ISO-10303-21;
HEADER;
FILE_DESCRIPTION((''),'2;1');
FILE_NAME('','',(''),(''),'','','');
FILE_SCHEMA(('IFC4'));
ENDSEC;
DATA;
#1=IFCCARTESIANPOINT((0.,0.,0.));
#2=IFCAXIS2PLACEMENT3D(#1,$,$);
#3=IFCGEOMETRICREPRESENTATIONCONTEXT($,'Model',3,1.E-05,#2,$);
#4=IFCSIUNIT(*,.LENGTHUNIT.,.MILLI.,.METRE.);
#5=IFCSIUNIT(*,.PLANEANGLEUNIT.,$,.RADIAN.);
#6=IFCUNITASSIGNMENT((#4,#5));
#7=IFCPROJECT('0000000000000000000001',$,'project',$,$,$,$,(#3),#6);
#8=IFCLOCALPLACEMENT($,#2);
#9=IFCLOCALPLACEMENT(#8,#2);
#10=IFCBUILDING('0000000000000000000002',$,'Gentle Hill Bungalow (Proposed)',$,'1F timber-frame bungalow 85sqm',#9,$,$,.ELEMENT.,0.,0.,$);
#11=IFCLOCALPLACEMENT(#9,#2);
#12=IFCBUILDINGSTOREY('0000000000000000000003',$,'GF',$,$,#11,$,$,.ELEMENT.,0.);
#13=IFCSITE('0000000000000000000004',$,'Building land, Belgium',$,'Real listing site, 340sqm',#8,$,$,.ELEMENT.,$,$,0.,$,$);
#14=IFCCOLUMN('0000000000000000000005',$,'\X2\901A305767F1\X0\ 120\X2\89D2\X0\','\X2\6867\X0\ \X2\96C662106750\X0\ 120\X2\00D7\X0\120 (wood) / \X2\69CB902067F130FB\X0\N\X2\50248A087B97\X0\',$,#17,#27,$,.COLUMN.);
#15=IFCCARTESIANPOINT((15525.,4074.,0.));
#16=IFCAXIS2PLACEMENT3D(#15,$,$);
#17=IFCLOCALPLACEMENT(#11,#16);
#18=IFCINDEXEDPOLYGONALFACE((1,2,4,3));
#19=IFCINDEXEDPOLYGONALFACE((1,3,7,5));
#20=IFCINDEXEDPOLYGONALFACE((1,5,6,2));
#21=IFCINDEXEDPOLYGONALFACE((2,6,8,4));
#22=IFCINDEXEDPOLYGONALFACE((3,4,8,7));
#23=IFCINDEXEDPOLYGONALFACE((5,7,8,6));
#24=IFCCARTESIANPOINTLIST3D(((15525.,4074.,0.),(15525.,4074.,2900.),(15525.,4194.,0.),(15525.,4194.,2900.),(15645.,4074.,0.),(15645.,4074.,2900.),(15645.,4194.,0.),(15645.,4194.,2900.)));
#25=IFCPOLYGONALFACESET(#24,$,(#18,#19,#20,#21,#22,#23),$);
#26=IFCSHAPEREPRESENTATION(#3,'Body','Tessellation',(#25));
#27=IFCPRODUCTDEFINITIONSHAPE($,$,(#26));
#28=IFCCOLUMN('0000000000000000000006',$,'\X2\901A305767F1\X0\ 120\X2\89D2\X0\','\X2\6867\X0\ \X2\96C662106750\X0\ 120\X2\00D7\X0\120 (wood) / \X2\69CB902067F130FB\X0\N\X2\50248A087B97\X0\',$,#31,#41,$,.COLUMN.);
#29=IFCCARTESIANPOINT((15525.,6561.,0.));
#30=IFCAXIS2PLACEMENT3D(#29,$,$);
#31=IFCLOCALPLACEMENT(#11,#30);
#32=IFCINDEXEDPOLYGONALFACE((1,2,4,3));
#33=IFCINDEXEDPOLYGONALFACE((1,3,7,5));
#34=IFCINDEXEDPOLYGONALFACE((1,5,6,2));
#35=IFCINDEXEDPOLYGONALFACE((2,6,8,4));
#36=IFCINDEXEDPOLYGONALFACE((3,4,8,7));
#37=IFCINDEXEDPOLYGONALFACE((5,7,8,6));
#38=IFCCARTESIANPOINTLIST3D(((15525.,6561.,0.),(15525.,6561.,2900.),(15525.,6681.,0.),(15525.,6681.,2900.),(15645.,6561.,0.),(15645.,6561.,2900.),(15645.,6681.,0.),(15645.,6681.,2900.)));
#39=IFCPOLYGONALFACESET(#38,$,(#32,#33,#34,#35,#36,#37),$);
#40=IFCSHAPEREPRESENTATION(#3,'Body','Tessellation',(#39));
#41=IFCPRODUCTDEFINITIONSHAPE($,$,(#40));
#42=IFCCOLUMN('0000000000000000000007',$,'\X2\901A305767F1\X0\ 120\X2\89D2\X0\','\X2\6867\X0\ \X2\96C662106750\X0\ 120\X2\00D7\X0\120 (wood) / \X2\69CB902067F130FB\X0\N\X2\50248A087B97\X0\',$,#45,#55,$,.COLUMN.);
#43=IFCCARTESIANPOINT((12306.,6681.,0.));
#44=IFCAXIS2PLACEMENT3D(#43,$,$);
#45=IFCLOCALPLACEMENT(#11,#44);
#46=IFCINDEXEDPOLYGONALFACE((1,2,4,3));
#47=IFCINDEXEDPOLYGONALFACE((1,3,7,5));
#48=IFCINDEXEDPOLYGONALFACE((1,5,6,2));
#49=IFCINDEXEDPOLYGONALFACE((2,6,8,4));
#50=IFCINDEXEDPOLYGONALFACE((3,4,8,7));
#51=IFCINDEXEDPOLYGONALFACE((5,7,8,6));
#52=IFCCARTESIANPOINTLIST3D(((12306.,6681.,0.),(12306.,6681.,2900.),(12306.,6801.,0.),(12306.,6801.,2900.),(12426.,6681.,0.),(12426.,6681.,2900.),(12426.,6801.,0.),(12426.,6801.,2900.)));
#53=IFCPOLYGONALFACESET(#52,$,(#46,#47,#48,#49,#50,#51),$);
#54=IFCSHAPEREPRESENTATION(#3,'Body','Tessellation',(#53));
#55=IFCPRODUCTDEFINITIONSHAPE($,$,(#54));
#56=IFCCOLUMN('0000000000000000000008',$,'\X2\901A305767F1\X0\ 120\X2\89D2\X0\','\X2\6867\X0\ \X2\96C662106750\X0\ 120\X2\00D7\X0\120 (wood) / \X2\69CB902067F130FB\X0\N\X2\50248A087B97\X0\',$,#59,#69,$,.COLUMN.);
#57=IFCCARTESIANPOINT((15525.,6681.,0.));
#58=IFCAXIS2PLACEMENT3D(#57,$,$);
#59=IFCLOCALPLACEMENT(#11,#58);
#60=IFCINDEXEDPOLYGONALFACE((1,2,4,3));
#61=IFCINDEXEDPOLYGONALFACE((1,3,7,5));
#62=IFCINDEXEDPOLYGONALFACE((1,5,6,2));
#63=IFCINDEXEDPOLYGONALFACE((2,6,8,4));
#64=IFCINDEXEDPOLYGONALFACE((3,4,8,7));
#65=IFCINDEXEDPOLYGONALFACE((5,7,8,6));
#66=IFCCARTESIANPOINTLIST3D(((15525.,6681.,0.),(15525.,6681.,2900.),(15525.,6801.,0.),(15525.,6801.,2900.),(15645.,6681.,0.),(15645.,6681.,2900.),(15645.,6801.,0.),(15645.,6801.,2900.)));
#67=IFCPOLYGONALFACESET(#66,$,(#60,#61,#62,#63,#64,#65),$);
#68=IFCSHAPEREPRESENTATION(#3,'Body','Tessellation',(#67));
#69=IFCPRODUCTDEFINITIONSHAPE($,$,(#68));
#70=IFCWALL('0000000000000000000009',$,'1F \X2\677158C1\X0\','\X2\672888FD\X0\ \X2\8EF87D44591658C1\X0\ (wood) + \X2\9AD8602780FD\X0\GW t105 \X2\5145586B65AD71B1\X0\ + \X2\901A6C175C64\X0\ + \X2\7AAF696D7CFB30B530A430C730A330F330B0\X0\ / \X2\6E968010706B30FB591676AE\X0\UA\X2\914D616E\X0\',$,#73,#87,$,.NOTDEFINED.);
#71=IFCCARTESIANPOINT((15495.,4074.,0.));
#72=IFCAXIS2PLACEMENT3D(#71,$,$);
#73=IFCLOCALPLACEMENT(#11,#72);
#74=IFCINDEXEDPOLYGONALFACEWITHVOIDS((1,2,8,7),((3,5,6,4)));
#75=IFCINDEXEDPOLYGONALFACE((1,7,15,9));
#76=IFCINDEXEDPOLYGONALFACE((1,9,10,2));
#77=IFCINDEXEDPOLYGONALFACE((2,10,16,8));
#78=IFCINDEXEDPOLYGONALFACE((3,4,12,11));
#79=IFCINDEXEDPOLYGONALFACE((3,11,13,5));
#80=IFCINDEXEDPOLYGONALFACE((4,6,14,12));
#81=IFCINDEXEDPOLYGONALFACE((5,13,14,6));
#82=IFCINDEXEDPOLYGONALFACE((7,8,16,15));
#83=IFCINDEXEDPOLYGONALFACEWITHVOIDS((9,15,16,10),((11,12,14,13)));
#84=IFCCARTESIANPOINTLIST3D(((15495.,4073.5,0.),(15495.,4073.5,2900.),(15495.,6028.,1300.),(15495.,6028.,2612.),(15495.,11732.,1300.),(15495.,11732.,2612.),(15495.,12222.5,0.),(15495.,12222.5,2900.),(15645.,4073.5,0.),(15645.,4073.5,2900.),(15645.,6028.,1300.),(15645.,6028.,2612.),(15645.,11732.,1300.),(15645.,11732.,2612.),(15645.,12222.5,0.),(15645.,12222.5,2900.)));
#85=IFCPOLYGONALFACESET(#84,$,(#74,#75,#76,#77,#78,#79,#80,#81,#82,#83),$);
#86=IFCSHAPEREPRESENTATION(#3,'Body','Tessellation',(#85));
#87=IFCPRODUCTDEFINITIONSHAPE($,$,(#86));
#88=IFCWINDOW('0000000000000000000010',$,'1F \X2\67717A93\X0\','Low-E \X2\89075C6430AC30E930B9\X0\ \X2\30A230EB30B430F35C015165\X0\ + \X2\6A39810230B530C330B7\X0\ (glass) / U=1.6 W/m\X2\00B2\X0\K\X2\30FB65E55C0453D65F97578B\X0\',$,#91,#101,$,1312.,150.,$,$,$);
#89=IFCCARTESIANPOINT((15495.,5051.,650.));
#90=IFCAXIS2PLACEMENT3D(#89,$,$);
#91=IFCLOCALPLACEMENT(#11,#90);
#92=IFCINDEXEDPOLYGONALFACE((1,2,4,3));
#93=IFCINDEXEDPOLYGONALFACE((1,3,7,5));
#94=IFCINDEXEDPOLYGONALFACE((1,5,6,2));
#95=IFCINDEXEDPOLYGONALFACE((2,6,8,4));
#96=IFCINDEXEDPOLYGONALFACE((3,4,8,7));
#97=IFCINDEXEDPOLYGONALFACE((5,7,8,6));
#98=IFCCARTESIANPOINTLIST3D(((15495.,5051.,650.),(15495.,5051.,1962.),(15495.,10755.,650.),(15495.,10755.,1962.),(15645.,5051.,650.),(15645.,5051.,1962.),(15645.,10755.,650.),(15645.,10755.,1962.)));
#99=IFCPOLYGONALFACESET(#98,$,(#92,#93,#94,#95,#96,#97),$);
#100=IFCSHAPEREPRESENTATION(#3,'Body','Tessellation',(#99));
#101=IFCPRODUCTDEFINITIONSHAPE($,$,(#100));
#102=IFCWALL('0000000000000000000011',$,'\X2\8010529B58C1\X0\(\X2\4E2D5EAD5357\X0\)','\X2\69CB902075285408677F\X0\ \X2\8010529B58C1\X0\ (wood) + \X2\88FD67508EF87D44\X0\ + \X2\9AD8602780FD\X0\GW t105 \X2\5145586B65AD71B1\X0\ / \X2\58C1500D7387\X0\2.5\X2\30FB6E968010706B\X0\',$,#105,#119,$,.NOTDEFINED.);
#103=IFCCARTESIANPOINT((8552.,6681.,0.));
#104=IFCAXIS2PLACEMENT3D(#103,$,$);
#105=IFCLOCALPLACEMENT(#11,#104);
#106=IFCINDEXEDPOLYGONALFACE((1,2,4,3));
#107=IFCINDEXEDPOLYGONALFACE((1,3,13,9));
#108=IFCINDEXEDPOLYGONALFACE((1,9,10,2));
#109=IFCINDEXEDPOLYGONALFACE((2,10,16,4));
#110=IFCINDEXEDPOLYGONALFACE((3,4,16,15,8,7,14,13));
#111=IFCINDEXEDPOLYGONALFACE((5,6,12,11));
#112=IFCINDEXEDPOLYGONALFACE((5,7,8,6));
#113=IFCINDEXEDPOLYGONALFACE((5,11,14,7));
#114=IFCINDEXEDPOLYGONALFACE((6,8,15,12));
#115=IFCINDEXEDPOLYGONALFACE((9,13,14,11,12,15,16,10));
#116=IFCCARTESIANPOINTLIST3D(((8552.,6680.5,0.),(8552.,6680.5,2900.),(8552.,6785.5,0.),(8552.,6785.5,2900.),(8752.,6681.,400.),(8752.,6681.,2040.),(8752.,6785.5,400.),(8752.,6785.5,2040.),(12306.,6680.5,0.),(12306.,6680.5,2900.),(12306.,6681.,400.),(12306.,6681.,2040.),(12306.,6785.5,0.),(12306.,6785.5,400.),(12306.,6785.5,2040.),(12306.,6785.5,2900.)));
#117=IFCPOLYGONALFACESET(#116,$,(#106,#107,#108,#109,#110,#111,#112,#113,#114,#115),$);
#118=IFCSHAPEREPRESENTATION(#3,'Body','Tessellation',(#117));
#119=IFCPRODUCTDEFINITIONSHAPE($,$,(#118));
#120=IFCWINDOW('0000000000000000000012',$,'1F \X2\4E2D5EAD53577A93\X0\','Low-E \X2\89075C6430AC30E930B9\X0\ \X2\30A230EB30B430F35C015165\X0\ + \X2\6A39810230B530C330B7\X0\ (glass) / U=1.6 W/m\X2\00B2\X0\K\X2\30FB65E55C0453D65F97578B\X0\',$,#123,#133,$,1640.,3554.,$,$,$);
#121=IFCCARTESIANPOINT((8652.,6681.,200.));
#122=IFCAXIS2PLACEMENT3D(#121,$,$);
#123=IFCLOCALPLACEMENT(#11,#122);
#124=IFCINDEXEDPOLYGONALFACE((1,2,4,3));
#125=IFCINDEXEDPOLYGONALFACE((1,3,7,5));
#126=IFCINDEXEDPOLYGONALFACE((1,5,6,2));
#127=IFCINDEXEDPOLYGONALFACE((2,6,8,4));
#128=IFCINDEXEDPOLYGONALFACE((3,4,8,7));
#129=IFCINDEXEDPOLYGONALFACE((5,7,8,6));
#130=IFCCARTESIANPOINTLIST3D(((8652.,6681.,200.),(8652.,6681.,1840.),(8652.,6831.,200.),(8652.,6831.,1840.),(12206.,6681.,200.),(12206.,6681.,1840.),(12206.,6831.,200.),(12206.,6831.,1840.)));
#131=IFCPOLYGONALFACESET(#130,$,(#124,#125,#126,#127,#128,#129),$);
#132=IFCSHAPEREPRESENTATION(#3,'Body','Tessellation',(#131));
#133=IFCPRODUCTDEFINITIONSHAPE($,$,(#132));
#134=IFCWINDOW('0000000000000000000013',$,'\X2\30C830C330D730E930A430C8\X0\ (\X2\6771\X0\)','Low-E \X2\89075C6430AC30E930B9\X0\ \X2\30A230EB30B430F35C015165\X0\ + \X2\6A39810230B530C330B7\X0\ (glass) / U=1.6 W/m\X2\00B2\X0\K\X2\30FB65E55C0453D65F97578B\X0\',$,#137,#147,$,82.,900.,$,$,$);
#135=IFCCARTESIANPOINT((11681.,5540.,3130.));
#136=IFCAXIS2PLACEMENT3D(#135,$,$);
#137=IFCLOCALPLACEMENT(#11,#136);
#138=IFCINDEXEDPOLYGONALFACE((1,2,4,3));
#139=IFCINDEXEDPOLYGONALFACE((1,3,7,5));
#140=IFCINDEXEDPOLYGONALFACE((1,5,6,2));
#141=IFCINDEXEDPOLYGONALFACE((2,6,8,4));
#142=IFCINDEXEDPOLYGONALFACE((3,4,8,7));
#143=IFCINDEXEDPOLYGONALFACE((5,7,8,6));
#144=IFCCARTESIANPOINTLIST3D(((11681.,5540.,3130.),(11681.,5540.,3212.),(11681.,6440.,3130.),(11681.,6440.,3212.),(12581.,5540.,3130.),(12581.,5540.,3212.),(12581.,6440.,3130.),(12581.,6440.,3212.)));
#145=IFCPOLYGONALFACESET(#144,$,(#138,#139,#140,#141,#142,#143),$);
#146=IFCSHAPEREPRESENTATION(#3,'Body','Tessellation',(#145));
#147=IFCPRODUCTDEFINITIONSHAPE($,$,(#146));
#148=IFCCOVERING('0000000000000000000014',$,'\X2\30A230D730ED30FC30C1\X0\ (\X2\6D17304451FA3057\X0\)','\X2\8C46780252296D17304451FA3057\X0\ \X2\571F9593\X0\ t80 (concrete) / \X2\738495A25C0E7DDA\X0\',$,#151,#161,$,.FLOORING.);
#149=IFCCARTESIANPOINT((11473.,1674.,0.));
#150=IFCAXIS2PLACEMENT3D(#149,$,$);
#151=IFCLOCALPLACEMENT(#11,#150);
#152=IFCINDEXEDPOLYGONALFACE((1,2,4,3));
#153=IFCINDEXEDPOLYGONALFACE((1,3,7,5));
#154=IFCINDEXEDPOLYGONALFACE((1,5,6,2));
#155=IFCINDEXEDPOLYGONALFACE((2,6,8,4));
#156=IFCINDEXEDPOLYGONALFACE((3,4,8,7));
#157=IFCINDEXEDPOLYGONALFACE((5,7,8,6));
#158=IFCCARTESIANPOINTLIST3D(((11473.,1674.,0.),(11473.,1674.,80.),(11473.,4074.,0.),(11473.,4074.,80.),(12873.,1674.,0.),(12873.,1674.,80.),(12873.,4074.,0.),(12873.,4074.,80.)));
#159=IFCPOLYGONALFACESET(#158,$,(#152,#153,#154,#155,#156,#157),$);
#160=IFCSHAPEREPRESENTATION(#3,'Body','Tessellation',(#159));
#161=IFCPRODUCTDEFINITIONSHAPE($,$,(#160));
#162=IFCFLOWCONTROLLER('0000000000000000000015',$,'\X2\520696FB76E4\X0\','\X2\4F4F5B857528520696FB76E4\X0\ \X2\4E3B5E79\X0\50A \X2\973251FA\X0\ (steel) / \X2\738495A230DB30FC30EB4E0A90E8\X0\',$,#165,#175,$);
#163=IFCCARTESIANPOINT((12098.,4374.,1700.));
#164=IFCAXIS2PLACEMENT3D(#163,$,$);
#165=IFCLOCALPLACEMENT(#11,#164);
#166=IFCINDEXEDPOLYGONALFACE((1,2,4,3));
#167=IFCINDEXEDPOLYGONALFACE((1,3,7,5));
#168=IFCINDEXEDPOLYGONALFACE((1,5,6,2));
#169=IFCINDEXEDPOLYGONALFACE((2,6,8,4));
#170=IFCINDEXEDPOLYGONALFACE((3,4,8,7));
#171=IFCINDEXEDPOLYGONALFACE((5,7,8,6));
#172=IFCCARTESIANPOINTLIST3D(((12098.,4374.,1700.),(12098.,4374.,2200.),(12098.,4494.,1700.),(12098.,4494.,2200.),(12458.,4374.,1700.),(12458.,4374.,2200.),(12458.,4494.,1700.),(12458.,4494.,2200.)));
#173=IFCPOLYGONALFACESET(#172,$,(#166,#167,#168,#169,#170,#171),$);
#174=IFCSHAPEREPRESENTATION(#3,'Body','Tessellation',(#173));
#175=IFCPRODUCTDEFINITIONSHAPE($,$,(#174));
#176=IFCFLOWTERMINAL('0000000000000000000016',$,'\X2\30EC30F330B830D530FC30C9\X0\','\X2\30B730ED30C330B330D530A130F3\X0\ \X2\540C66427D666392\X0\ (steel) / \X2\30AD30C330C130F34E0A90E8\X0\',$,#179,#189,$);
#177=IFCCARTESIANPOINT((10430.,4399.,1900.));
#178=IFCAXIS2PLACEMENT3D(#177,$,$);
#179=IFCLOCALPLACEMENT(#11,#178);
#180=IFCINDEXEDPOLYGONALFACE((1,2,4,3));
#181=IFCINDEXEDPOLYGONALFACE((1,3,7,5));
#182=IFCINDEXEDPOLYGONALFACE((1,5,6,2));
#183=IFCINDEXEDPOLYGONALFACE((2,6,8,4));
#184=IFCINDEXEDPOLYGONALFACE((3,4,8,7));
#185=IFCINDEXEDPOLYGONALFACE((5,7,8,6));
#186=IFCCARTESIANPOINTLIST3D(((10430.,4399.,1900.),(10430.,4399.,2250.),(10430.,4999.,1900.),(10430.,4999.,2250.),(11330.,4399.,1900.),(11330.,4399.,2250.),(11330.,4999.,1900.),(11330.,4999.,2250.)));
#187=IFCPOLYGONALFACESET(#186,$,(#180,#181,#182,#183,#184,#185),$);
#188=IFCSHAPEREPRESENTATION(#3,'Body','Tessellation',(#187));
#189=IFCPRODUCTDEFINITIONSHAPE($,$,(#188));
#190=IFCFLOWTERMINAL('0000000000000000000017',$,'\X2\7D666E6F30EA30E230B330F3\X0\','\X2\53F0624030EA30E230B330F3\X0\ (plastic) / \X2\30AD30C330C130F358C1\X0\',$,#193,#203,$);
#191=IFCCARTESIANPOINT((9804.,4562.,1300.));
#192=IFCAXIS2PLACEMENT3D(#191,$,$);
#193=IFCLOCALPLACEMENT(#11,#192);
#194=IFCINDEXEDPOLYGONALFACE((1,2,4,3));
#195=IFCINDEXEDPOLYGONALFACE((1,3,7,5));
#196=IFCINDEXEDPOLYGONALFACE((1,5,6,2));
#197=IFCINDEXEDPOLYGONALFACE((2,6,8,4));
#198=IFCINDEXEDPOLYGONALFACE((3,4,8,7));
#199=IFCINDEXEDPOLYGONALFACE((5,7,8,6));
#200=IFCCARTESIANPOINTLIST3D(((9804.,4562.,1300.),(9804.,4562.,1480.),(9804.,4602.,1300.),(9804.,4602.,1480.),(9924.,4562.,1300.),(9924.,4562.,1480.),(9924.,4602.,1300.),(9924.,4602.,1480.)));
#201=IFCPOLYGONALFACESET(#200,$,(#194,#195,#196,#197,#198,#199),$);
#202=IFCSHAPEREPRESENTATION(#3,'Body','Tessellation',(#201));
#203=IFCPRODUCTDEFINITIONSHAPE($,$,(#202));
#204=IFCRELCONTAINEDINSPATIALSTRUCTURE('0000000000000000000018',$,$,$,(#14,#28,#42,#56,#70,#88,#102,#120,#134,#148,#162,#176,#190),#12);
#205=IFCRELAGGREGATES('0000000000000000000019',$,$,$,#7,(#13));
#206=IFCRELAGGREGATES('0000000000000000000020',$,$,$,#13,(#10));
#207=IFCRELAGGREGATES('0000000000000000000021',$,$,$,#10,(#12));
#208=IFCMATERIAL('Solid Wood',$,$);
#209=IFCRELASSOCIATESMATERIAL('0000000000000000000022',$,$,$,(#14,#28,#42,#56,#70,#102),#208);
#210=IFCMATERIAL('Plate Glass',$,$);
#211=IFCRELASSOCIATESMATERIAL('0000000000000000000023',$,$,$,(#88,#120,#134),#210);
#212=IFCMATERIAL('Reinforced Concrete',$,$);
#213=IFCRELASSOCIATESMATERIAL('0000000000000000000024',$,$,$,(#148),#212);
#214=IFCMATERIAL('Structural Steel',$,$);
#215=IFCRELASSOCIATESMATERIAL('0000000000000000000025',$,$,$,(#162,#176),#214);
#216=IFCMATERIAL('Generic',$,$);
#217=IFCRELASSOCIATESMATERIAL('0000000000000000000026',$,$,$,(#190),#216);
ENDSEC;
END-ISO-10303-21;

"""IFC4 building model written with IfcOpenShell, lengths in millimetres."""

from ifc_helpers import new_model, si_unit, frame, frame_2d, origin, place, context, project, spatial, rectangle, extrude, material, element, fill, save


model = new_model("IFC4")

# Units and contexts
model_context = context("Model", 3, precision=1e-05, world=origin())
ifc_project = project(units=[si_unit("LENGTHUNIT", "METRE", prefix="MILLI"), si_unit("PLANEANGLEUNIT", "RADIAN")], contexts=[model_context])

# Site, building, storey
site_placement = place(None, origin())
site = spatial("IfcSite", under=ifc_project, at=site_placement, Name="Building land, Belgium", ObjectType="Real listing site, 340sqm", CompositionType="ELEMENT", RefElevation=0.0)
building_placement = place(site_placement, origin())
building = spatial("IfcBuilding", under=site, at=building_placement, Name="Gentle Hill Bungalow (Proposed)", ObjectType="1F timber-frame bungalow 85sqm", CompositionType="ELEMENT", ElevationOfRefHeight=0.0, ElevationOfTerrain=0.0)
storey_placement = place(building_placement, origin())
storey = spatial("IfcBuildingStorey", under=building, at=storey_placement, Name="GF", CompositionType="ELEMENT", Elevation=0.0)

# Columns
ifc_material_1 = material(Name="Solid Wood")
column_1_placement = place(storey_placement, frame((15525.0, 4074.0, 0.0)))
element("IfcColumn", 1, at=column_1_placement, inside=storey, material=ifc_material_1, Name="通し柱 120角", Description="桧 集成材 120×120 (wood) / 構造柱・N値計算", PredefinedType="COLUMN", context=model_context, shape_type="SweptSolid", body=[
    extrude(rectangle(XDim=120.0, YDim=120.0, at=frame_2d((60.0, 60.0))), frame((15525.0, 4074.0, 0.0)), (0.0, 0.0, 1.0), 2900.0),
])
column_2_placement = place(storey_placement, frame((15525.0, 6561.0, 0.0)))
element("IfcColumn", 2, at=column_2_placement, inside=storey, material=ifc_material_1, Name="通し柱 120角", Description="桧 集成材 120×120 (wood) / 構造柱・N値計算", PredefinedType="COLUMN", context=model_context, shape_type="SweptSolid", body=[
    extrude(rectangle(XDim=120.0, YDim=120.0, at=frame_2d((60.0, 60.0))), frame((15525.0, 6561.0, 0.0)), (0.0, 0.0, 1.0), 2900.0),
])
column_3_placement = place(storey_placement, frame((12306.0, 6681.0, 0.0)))
element("IfcColumn", 3, at=column_3_placement, inside=storey, material=ifc_material_1, Name="通し柱 120角", Description="桧 集成材 120×120 (wood) / 構造柱・N値計算", PredefinedType="COLUMN", context=model_context, shape_type="SweptSolid", body=[
    extrude(rectangle(XDim=120.0, YDim=120.0, at=frame_2d((60.0, 60.0))), frame((12306.0, 6681.0, 0.0)), (0.0, 0.0, 1.0), 2900.0),
])
column_4_placement = place(storey_placement, frame((15525.0, 6681.0, 0.0)))
element("IfcColumn", 4, at=column_4_placement, inside=storey, material=ifc_material_1, Name="通し柱 120角", Description="桧 集成材 120×120 (wood) / 構造柱・N値計算", PredefinedType="COLUMN", context=model_context, shape_type="SweptSolid", body=[
    extrude(rectangle(XDim=120.0, YDim=120.0, at=frame_2d((60.0, 60.0))), frame((15525.0, 6681.0, 0.0)), (0.0, 0.0, 1.0), 2900.0),
])

# Walls, openings, windows
wall_1_placement = place(storey_placement, frame((15495.0, 4074.0, 0.0)))
wall_1 = element("IfcWall", 5, at=wall_1_placement, inside=storey, material=ifc_material_1, Name="1F 東壁", Description="木製 軸組外壁 (wood) + 高性能GW t105 充填断熱 + 通気層 + 窯業系サイディング / 準耐火・外皮UA配慮", PredefinedType="NOTDEFINED", context=model_context, shape_type="SweptSolid", body=[
    extrude(rectangle(XDim=150.0, YDim=8149.0, at=frame_2d((75.0, 4074.0))), frame((15495.0, 4074.0, 0.0)), (0.0, 0.0, 1.0), 2900.0),
])
opening_1_placement = place(storey_placement, frame((15495.0, 5051.0, 650.0)))
opening_1 = element("IfcOpeningElement", 6, at=opening_1_placement, cuts=wall_1, PredefinedType="NOTDEFINED", context=model_context, shape_type="SweptSolid", body=[
    extrude(rectangle(XDim=150.0, YDim=5704.0, at=frame_2d((75.0, 2852.0))), frame((15495.0, 5051.0, 650.0)), (0.0, 0.0, 1.0), 1312.0),
])
ifc_material_2 = material(Name="Plate Glass")
window_1_placement = place(storey_placement, frame((15495.0, 5051.0, 650.0)))
window_1 = element("IfcWindow", 7, at=window_1_placement, inside=storey, material=ifc_material_2, Name="1F 東窓", Description="Low-E 複層ガラス アルゴン封入 + 樹脂サッシ (glass) / U=1.6 W/m²K・日射取得型", OverallHeight=1312.0, OverallWidth=150.0, context=model_context, shape_type="SweptSolid", body=[
    extrude(rectangle(XDim=150.0, YDim=5704.0, at=frame_2d((75.0, 2852.0))), frame((15495.0, 5051.0, 650.0)), (0.0, 0.0, 1.0), 1312.0),
])
fill(opening_1, window_1)
wall_2_placement = place(storey_placement, frame((8552.0, 6681.0, 0.0)))
wall_2 = element("IfcWall", 8, at=wall_2_placement, inside=storey, material=ifc_material_1, Name="耐力壁(中庭南)", Description="構造用合板 耐力壁 (wood) + 製材軸組 + 高性能GW t105 充填断熱 / 壁倍率2.5・準耐火", PredefinedType="NOTDEFINED", context=model_context, shape_type="SweptSolid", body=[
    extrude(rectangle(XDim=3754.0, YDim=105.0, at=frame_2d((1877.0, 52.0))), frame((8552.0, 6681.0, 0.0)), (0.0, 0.0, 1.0), 2900.0),
])
opening_2_placement = place(storey_placement, frame((8652.0, 6681.0, 200.0)))
opening_2 = element("IfcOpeningElement", 9, at=opening_2_placement, cuts=wall_2, PredefinedType="NOTDEFINED", context=model_context, shape_type="SweptSolid", body=[
    extrude(rectangle(XDim=3554.0, YDim=150.0, at=frame_2d((1777.0, 75.0))), frame((8652.0, 6681.0, 200.0)), (0.0, 0.0, 1.0), 1640.0),
])
window_2_placement = place(storey_placement, frame((8652.0, 6681.0, 200.0)))
window_2 = element("IfcWindow", 10, at=window_2_placement, inside=storey, material=ifc_material_2, Name="1F 中庭南窓", Description="Low-E 複層ガラス アルゴン封入 + 樹脂サッシ (glass) / U=1.6 W/m²K・日射取得型", OverallHeight=1640.0, OverallWidth=3554.0, context=model_context, shape_type="SweptSolid", body=[
    extrude(rectangle(XDim=3554.0, YDim=150.0, at=frame_2d((1777.0, 75.0))), frame((8652.0, 6681.0, 200.0)), (0.0, 0.0, 1.0), 1640.0),
])
fill(opening_2, window_2)

# Window
window_3_placement = place(storey_placement, frame((11681.0, 5540.0, 3130.0)))
element("IfcWindow", 11, at=window_3_placement, inside=storey, material=ifc_material_2, Name="トップライト (東)", Description="Low-E 複層ガラス アルゴン封入 + 樹脂サッシ (glass) / U=1.6 W/m²K・日射取得型", OverallHeight=82.0, OverallWidth=900.0, context=model_context, shape_type="SweptSolid", body=[
    extrude(rectangle(XDim=900.0, YDim=900.0, at=frame_2d((450.0, 450.0))), frame((11681.0, 5540.0, 3130.0)), (0.0, 0.0, 1.0), 82.0),
])

# Shared definitions
ifc_material_3 = material(Name="Structural Steel")

# Covering
ifc_material_4 = material(Name="Reinforced Concrete")
covering_placement = place(storey_placement, frame((11473.0, 1674.0, 0.0)))
element("IfcCovering", 12, at=covering_placement, inside=storey, material=ifc_material_4, Name="アプローチ (洗い出し)", Description="豆砂利洗い出し 土間 t80 (concrete) / 玄関導線", PredefinedType="FLOORING", context=model_context, shape_type="SweptSolid", body=[
    extrude(rectangle(XDim=1400.0, YDim=2400.0, at=frame_2d((700.0, 1200.0))), frame((11473.0, 1674.0, 0.0)), (0.0, 0.0, 1.0), 80.0),
])

# Flow controller
flow_controller_placement = place(storey_placement, frame((12098.0, 4374.0, 1700.0)))
element("IfcFlowController", 13, at=flow_controller_placement, inside=storey, material=ifc_material_3, Name="分電盤", Description="住宅用分電盤 主幹50A 露出 (steel) / 玄関ホール上部", context=model_context, shape_type="SweptSolid", body=[
    extrude(rectangle(XDim=360.0, YDim=120.0, at=frame_2d((180.0, 60.0))), frame((12098.0, 4374.0, 1700.0)), (0.0, 0.0, 1.0), 500.0),
])

# Flow terminals
flow_terminal_1_placement = place(storey_placement, frame((10430.0, 4399.0, 1900.0)))
element("IfcFlowTerminal", 14, at=flow_terminal_1_placement, inside=storey, material=ifc_material_3, Name="レンジフード", Description="シロッコファン 同時給排 (steel) / キッチン上部", context=model_context, shape_type="SweptSolid", body=[
    extrude(rectangle(XDim=900.0, YDim=600.0, at=frame_2d((450.0, 300.0))), frame((10430.0, 4399.0, 1900.0)), (0.0, 0.0, 1.0), 350.0),
])
ifc_material_5 = material(Name="Generic")
flow_terminal_2_placement = place(storey_placement, frame((9804.0, 4562.0, 1300.0)))
element("IfcFlowTerminal", 15, at=flow_terminal_2_placement, inside=storey, material=ifc_material_5, Name="給湯リモコン", Description="台所リモコン (plastic) / キッチン壁", context=model_context, shape_type="SweptSolid", body=[
    extrude(rectangle(XDim=120.0, YDim=40.0, at=frame_2d((60.0, 20.0))), frame((9804.0, 4562.0, 1300.0)), (0.0, 0.0, 1.0), 180.0),
])

save(model, "model.ifc")
